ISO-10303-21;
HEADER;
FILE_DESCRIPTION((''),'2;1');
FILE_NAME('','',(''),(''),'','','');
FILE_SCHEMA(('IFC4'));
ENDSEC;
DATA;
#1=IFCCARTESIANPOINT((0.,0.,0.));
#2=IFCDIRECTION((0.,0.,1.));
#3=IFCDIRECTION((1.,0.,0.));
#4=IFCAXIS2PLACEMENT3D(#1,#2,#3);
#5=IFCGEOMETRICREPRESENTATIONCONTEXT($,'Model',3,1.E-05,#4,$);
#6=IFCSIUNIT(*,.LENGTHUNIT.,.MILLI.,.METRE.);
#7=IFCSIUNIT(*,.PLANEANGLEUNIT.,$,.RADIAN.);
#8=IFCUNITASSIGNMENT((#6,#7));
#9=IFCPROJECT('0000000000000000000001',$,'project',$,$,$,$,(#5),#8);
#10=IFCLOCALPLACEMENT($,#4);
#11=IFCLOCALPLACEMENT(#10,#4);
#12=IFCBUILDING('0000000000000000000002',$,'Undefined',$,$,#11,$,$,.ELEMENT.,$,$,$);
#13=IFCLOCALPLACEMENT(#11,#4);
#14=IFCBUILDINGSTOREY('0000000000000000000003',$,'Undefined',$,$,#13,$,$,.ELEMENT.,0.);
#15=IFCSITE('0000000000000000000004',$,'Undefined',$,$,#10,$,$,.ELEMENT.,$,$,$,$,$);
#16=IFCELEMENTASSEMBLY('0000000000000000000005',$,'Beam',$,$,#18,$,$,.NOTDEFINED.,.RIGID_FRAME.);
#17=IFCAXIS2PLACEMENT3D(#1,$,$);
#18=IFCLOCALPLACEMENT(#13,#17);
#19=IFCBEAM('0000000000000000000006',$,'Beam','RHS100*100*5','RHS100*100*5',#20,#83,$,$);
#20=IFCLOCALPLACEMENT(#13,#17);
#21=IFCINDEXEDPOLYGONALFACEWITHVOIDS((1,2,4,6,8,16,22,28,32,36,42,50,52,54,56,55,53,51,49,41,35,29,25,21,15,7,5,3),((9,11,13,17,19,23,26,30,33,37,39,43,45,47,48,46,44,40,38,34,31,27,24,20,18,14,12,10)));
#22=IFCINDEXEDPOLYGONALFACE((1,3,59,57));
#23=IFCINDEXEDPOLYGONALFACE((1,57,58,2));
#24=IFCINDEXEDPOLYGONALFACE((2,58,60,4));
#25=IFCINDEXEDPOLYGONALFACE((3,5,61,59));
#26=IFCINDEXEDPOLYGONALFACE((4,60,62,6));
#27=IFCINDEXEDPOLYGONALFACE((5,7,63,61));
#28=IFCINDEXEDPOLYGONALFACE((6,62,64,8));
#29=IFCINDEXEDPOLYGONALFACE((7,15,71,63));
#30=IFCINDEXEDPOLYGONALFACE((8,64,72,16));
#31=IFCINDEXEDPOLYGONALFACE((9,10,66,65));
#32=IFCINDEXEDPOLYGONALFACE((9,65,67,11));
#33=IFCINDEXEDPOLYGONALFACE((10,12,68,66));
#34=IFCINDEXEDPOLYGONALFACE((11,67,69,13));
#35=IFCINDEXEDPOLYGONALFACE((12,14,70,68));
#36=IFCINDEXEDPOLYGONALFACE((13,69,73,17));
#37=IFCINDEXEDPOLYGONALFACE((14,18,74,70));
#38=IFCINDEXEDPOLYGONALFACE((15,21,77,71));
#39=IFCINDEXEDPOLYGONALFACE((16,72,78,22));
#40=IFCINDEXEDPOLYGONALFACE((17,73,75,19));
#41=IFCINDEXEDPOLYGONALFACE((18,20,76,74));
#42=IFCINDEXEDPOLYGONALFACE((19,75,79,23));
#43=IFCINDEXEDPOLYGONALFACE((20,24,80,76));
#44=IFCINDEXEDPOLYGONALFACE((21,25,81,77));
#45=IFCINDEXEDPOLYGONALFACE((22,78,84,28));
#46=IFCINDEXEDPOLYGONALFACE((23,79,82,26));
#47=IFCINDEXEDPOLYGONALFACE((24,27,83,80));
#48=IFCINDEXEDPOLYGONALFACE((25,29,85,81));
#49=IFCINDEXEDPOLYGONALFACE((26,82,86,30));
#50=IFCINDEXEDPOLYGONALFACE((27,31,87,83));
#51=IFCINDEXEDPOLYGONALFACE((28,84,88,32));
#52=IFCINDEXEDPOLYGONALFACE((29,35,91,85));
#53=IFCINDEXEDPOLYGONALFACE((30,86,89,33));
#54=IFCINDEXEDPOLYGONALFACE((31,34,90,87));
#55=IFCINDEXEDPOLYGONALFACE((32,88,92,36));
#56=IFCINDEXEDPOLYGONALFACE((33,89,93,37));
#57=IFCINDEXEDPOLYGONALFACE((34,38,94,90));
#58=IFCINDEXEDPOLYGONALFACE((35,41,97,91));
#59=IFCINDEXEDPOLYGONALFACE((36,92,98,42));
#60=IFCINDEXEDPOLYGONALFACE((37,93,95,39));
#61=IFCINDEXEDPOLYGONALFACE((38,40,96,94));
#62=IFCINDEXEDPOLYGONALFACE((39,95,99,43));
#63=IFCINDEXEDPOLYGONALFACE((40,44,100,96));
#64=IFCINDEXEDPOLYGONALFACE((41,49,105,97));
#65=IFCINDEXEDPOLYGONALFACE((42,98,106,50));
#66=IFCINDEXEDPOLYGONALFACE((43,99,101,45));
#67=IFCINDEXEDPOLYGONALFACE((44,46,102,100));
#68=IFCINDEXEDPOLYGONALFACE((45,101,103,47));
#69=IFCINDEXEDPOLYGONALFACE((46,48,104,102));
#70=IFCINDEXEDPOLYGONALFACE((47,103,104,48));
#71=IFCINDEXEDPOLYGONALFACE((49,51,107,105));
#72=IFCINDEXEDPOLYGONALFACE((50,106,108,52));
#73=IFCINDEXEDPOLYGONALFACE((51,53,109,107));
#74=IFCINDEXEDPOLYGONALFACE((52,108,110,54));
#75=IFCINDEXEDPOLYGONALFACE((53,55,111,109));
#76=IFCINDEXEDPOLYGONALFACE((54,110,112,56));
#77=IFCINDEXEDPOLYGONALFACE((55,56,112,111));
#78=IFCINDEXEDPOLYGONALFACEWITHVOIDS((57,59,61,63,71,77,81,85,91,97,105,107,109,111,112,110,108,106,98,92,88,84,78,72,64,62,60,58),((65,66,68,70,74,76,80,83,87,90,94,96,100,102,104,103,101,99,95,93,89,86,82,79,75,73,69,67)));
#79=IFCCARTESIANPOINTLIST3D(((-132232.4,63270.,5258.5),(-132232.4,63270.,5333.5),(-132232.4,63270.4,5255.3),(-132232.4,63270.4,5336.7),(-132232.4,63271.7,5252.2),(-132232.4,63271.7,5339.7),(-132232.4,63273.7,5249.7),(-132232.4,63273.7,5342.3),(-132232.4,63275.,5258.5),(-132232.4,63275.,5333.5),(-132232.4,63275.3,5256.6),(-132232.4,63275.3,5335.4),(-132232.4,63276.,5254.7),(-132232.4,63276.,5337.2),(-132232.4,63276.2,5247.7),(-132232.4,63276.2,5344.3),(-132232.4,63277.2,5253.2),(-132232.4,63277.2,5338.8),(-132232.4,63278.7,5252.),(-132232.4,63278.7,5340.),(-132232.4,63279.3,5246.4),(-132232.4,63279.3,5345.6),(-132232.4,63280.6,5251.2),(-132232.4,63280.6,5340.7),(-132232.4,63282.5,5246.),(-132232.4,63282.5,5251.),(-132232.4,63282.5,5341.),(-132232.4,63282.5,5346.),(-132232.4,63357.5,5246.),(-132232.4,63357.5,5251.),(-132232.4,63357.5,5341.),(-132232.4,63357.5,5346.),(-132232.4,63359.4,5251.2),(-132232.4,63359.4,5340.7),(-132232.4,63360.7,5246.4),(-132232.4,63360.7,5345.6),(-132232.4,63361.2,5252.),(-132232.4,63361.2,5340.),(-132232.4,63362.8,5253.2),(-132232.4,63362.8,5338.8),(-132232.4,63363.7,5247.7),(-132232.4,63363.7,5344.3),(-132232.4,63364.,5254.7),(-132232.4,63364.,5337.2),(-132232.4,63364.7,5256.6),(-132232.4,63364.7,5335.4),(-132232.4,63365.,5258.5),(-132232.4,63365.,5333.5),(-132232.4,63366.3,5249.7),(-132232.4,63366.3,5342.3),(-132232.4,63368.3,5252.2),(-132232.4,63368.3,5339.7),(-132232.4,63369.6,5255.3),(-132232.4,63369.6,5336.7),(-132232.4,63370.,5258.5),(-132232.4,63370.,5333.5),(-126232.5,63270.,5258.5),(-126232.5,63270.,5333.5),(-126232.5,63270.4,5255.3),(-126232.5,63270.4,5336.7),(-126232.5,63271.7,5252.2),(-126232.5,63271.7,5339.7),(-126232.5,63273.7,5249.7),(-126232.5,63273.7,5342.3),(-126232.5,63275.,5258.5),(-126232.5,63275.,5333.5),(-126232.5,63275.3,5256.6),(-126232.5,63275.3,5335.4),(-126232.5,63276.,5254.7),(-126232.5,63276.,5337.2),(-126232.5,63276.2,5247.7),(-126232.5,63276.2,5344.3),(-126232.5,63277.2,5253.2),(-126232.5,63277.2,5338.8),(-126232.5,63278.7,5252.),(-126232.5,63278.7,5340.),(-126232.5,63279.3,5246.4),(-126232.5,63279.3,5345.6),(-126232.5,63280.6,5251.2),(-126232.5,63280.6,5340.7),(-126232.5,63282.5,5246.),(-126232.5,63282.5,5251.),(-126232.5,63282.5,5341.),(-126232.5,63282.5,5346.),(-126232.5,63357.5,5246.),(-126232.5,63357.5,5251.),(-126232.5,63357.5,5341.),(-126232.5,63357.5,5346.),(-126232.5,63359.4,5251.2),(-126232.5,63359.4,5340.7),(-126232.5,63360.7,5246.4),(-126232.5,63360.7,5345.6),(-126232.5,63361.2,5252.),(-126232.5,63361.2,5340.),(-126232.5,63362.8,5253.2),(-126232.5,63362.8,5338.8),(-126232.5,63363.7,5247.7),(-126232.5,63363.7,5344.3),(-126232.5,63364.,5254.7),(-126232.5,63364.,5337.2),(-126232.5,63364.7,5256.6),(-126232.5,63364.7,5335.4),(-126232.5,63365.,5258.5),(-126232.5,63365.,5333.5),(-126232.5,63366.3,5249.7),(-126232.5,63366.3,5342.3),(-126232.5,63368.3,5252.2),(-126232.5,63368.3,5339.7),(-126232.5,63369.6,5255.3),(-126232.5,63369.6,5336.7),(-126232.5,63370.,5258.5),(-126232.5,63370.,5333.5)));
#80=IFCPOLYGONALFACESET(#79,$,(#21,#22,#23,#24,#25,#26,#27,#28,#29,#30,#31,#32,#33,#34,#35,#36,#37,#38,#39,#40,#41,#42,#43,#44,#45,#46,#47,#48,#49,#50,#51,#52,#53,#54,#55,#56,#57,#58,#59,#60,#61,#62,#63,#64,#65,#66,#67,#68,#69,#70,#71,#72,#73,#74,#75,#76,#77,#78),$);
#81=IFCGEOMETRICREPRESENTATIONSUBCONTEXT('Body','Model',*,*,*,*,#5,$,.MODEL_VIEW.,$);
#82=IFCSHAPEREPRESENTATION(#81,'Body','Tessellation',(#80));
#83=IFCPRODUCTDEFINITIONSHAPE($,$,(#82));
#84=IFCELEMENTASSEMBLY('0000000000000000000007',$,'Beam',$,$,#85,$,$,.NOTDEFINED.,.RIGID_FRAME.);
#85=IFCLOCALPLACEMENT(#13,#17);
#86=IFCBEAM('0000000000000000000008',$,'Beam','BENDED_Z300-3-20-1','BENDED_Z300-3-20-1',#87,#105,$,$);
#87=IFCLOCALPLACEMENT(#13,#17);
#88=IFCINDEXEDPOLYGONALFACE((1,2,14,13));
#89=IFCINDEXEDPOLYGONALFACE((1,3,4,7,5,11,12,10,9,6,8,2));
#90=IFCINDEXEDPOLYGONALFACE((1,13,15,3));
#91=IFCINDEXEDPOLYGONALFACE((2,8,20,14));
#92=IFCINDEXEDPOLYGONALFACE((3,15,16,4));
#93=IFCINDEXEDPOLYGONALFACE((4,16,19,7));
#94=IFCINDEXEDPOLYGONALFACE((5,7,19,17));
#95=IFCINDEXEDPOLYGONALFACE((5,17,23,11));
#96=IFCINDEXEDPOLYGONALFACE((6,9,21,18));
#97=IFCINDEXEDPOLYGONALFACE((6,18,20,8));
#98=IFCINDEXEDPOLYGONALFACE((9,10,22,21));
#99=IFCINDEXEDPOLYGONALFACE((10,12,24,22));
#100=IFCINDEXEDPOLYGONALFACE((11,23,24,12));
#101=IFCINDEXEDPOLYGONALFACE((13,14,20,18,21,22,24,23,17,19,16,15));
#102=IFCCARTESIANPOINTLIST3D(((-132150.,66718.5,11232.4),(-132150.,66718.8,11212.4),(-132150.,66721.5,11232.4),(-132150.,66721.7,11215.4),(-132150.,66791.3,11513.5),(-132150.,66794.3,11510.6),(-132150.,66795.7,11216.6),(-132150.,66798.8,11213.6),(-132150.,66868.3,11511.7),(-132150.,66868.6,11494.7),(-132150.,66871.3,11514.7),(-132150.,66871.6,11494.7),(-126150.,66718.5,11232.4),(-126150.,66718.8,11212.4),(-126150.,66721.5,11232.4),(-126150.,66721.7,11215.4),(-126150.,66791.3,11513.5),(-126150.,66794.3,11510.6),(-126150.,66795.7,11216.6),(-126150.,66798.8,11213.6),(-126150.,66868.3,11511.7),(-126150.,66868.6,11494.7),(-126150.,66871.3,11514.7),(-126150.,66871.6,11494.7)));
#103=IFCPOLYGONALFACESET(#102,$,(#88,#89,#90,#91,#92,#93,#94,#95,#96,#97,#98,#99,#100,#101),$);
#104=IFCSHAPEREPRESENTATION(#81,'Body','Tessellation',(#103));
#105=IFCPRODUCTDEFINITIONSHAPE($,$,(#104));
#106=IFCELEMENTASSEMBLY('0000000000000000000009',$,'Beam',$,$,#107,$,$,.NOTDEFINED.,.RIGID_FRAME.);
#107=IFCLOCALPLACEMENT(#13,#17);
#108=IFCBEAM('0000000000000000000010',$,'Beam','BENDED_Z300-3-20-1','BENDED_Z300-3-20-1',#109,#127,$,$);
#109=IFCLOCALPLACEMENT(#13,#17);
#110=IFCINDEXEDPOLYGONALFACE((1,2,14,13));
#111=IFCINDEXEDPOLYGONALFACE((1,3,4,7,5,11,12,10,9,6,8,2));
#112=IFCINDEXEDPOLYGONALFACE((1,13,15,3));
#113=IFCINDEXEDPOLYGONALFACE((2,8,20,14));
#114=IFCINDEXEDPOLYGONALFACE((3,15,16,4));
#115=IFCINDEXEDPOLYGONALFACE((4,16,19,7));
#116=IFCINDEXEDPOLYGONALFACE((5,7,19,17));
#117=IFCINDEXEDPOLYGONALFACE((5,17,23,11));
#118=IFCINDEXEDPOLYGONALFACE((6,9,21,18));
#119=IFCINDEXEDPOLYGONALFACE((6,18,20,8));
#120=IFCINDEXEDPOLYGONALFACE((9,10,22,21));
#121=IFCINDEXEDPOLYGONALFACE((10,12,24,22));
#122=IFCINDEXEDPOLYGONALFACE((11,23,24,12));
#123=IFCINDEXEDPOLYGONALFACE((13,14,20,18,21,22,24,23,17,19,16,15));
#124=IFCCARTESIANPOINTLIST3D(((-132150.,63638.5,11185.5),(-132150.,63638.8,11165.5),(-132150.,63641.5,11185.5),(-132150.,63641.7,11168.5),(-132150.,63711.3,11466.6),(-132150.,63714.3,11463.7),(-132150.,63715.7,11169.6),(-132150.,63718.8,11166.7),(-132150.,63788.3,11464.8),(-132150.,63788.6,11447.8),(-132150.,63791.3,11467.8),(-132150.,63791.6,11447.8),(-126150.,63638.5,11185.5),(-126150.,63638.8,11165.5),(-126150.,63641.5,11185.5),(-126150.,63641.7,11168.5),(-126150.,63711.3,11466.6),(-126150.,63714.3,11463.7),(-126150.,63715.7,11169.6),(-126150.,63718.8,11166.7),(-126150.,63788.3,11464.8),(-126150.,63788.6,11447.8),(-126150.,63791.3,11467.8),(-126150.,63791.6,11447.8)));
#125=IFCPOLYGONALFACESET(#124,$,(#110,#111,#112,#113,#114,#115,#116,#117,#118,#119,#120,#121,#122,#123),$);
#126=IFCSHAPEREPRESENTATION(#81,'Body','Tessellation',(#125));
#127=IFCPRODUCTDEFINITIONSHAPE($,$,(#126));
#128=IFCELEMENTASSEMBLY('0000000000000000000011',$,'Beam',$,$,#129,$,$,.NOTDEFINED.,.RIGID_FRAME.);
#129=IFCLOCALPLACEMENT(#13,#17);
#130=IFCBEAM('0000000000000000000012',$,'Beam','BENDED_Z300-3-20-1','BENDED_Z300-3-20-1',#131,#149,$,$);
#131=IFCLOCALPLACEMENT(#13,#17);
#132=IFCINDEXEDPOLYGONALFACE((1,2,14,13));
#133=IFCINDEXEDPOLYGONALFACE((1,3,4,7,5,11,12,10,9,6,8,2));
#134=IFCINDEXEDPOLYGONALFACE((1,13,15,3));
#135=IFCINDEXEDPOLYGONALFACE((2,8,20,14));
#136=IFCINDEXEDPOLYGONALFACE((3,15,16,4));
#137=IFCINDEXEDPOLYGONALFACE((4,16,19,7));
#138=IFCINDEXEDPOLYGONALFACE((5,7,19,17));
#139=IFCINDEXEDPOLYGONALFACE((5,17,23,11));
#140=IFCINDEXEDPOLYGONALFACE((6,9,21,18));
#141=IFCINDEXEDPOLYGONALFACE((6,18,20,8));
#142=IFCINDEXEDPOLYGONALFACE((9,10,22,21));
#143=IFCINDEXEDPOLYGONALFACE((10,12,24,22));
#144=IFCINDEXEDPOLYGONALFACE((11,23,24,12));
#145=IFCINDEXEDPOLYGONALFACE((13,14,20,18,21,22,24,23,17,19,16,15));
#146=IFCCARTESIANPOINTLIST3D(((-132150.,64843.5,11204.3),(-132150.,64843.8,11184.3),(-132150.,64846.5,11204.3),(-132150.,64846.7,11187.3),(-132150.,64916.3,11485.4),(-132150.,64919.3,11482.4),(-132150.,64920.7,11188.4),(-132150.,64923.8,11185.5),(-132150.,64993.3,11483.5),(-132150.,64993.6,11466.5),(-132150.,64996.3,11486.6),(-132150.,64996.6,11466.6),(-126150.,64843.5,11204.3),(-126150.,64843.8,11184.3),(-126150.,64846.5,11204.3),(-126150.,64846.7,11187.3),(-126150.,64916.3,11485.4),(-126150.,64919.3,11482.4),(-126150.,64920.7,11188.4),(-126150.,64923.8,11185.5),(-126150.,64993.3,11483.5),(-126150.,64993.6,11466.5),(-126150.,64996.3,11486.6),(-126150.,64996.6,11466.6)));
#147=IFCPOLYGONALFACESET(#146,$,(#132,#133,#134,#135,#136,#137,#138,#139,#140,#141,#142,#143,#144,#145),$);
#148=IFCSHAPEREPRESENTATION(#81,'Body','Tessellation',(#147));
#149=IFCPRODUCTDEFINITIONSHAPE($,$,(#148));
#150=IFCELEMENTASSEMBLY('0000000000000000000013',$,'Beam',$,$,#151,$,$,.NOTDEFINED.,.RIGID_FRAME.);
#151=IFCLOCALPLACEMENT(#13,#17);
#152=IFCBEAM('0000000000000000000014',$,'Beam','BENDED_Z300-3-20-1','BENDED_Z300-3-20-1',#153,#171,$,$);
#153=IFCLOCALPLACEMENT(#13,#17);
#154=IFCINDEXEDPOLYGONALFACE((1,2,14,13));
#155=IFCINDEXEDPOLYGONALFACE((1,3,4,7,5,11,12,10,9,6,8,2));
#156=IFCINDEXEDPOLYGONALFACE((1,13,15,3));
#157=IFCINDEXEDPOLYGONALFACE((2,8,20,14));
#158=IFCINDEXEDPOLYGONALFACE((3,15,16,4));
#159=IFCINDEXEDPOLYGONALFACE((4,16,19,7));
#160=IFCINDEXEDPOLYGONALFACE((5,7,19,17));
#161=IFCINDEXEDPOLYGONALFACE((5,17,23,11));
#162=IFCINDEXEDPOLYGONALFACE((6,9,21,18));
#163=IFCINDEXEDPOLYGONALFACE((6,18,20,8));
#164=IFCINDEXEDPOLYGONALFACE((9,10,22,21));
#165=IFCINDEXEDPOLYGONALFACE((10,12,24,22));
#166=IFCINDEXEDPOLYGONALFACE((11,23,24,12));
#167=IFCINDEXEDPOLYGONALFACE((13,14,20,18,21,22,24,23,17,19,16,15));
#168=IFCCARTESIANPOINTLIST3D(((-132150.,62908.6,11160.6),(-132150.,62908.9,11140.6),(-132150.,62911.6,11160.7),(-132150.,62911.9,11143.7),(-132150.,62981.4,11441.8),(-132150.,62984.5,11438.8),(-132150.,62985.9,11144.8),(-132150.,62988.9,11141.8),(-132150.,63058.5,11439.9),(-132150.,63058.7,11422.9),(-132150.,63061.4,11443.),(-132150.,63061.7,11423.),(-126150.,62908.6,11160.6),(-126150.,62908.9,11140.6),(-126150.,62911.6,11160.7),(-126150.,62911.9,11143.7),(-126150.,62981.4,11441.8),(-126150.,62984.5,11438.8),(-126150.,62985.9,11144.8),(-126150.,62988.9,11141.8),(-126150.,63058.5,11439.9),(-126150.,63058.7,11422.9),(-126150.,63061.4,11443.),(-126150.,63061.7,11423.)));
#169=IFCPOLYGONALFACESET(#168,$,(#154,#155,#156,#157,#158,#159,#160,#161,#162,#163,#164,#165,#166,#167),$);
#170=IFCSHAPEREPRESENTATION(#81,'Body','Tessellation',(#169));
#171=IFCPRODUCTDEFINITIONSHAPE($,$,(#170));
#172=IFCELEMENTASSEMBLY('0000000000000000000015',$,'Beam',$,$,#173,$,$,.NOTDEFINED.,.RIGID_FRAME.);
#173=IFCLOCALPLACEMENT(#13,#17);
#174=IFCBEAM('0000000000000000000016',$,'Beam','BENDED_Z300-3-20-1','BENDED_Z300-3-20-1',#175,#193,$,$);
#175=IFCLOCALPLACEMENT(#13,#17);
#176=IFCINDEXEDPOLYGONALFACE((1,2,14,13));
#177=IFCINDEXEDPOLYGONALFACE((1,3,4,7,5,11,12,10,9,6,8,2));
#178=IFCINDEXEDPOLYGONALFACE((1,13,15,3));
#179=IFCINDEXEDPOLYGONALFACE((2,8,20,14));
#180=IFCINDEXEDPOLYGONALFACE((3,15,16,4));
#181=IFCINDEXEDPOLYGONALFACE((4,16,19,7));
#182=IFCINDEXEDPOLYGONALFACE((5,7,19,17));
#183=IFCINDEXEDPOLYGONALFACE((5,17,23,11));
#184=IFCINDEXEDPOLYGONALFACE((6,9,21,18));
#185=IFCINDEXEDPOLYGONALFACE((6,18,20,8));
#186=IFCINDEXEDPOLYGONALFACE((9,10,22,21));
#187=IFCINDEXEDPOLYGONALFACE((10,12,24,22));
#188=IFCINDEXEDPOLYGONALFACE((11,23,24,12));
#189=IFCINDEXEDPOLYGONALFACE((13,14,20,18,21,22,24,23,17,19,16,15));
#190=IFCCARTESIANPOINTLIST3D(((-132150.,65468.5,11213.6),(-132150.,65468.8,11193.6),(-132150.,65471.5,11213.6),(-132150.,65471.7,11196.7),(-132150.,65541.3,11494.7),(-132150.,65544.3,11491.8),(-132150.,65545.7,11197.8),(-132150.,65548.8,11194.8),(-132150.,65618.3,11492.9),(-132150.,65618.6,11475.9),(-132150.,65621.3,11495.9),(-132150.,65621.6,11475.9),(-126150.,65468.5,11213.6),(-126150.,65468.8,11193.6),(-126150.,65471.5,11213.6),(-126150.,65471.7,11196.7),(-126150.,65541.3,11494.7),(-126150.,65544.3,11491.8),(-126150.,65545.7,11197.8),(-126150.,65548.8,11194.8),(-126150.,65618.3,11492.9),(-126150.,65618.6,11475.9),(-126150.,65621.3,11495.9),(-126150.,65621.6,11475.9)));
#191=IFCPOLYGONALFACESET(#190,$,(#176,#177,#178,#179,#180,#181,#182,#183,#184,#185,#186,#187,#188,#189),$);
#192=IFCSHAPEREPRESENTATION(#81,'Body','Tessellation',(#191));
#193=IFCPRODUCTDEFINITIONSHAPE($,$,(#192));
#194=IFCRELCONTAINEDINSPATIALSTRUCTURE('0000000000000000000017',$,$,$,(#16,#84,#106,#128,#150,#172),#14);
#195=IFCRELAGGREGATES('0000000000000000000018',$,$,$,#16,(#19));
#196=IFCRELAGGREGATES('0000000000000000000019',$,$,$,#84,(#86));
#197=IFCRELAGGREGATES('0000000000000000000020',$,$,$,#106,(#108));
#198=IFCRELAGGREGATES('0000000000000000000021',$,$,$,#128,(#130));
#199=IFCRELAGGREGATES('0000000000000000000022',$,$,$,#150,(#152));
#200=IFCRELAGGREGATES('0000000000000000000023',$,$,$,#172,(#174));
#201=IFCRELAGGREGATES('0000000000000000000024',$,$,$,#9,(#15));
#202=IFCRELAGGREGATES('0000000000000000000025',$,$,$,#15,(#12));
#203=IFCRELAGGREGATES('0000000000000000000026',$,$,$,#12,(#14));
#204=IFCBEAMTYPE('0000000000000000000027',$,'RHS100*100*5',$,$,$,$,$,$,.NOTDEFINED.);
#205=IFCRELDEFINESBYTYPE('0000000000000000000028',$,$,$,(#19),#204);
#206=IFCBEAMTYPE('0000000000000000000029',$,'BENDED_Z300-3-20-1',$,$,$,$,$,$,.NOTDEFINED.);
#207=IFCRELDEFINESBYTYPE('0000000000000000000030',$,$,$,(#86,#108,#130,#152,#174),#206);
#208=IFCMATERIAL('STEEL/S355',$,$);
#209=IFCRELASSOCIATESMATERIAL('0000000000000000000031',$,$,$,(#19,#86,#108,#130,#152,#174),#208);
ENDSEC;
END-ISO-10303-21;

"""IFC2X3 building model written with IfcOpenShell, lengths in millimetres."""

from ifc_helpers import new_model, si_unit, frame, origin_with_axes, origin_2d_with_axis, place, context, subcontext, project, spatial, polyline, hollow_rectangle, outline, extrude, material, type_object, element, aggregate, save


model = new_model("IFC2X3")

# Units and contexts
model_context = context("Model", 3, precision=1e-05, world=origin_with_axes())
body_context = subcontext(model_context, "Body", "Model", "MODEL_VIEW")
ifc_project = project(units=[si_unit("LENGTHUNIT", "METRE", prefix="MILLI"), si_unit("PLANEANGLEUNIT", "RADIAN")], contexts=[model_context])

# Site, building, storey
site_placement = place(None, origin_with_axes())
site = spatial("IfcSite", under=ifc_project, at=site_placement, Name="Undefined", CompositionType="ELEMENT")
building_placement = place(site_placement, origin_with_axes())
building = spatial("IfcBuilding", under=site, at=building_placement, Name="Undefined", CompositionType="ELEMENT")
storey_placement = place(building_placement, origin_with_axes())
storey = spatial("IfcBuildingStorey", under=building, at=storey_placement, Name="Undefined", CompositionType="ELEMENT", Elevation=0.0)

# Element assemblies, beams
ifc_material_1 = material(Name="STEEL/S355")
beam_type_1 = type_object("IfcBeamType", Name="RHS100*100*5", PredefinedType="NOTDEFINED")
assembly_1_placement = place(storey_placement, origin_with_axes())
assembly_1 = element("IfcElementAssembly", 1, at=assembly_1_placement, inside=storey, Name="Beam", AssemblyPlace="NOTDEFINED", PredefinedType="RIGID_FRAME")
beam_1_placement = place(assembly_1_placement, frame((-126232.5, 63320.0, 5296.0), z_axis=(0.0, 0.0, 1.0), x_axis=(-1.0, 0.0, 0.0)))
beam_1 = element("IfcBeam", 2, at=beam_1_placement, type_object=beam_type_1, material=ifc_material_1, Name="Beam", Description="RHS100*100*5", ObjectType="RHS100*100*5", context=body_context, shape_type="SweptSolid", body=[
    extrude(hollow_rectangle(XDim=100.0, YDim=100.0, WallThickness=5.0, InnerFilletRadius=7.5, OuterFilletRadius=12.5, at=origin_2d_with_axis()), frame((5999.9, 0.0, 0.0), z_axis=(-1.0, 0.0, 0.0), x_axis=(0.0, -1.0, 0.0)), (0.0, 0.0, 1.0), 5999.9),
])
aggregate(assembly_1, [beam_1])
assembly_2_placement = place(storey_placement, origin_with_axes())
assembly_2 = element("IfcElementAssembly", 3, at=assembly_2_placement, inside=storey, Name="Beam", AssemblyPlace="NOTDEFINED", PredefinedType="RIGID_FRAME")
beam_type_2 = type_object("IfcBeamType", Name="BENDED_Z300-3-20-1", PredefinedType="NOTDEFINED")
beam_2_placement = place(assembly_2_placement, frame((-126150.0, 66795.0, 11363.6), z_axis=(0.0, -0.014963, 0.999888), x_axis=(-1.0, 0.0, 0.0)))
beam_2 = element("IfcBeam", 4, at=beam_2_placement, type_object=beam_type_2, material=ifc_material_1, Name="Beam", Description="BENDED_Z300-3-20-1", ObjectType="BENDED_Z300-3-20-1", context=body_context, shape_type="SweptSolid", body=[
    extrude(outline(polyline([(1.5, -150.0), (-78.5, -150.0), (-78.5, -130.0), (-75.5, -130.0), (-75.5, -147.0), (-1.5, -147.0), (-1.5, 150.0), (78.5, 150.0), (78.5, 130.0), (75.5, 130.0), (75.5, 147.0), (1.5, 147.0), (1.5, -150.0)])), frame((6000.0, 0.0, 0.0), z_axis=(-1.0, 0.0, 0.0), x_axis=(0.0, -1.0, 0.0)), (0.0, 0.0, 1.0), 6000.0),
])
aggregate(assembly_2, [beam_2])
assembly_3_placement = place(storey_placement, origin_with_axes())
assembly_3 = element("IfcElementAssembly", 5, at=assembly_3_placement, inside=storey, Name="Beam", AssemblyPlace="NOTDEFINED", PredefinedType="RIGID_FRAME")
beam_3_placement = place(assembly_3_placement, frame((-126150.0, 63715.0, 11316.6), z_axis=(0.0, -0.014963, 0.999888), x_axis=(-1.0, 0.0, 0.0)))
beam_3 = element("IfcBeam", 6, at=beam_3_placement, type_object=beam_type_2, material=ifc_material_1, Name="Beam", Description="BENDED_Z300-3-20-1", ObjectType="BENDED_Z300-3-20-1", context=body_context, shape_type="SweptSolid", body=[
    extrude(outline(polyline([(1.5, -150.0), (-78.5, -150.0), (-78.5, -130.0), (-75.5, -130.0), (-75.5, -147.0), (-1.5, -147.0), (-1.5, 150.0), (78.5, 150.0), (78.5, 130.0), (75.5, 130.0), (75.5, 147.0), (1.5, 147.0), (1.5, -150.0)])), frame((6000.0, 0.0, 0.0), z_axis=(-1.0, 0.0, 0.0), x_axis=(0.0, -1.0, 0.0)), (0.0, 0.0, 1.0), 6000.0),
])
aggregate(assembly_3, [beam_3])
assembly_4_placement = place(storey_placement, origin_with_axes())
assembly_4 = element("IfcElementAssembly", 7, at=assembly_4_placement, inside=storey, Name="Beam", AssemblyPlace="NOTDEFINED", PredefinedType="RIGID_FRAME")
beam_4_placement = place(assembly_4_placement, frame((-126150.0, 64920.0, 11335.4), z_axis=(0.0, -0.014963, 0.999888), x_axis=(-1.0, 0.0, 0.0)))
beam_4 = element("IfcBeam", 8, at=beam_4_placement, type_object=beam_type_2, material=ifc_material_1, Name="Beam", Description="BENDED_Z300-3-20-1", ObjectType="BENDED_Z300-3-20-1", context=body_context, shape_type="SweptSolid", body=[
    extrude(outline(polyline([(1.5, -150.0), (-78.5, -150.0), (-78.5, -130.0), (-75.5, -130.0), (-75.5, -147.0), (-1.5, -147.0), (-1.5, 150.0), (78.5, 150.0), (78.5, 130.0), (75.5, 130.0), (75.5, 147.0), (1.5, 147.0), (1.5, -150.0)])), frame((6000.0, 0.0, 0.0), z_axis=(-1.0, 0.0, 0.0), x_axis=(0.0, -1.0, 0.0)), (0.0, 0.0, 1.0), 6000.0),
])
aggregate(assembly_4, [beam_4])
assembly_5_placement = place(storey_placement, origin_with_axes())
assembly_5 = element("IfcElementAssembly", 9, at=assembly_5_placement, inside=storey, Name="Beam", AssemblyPlace="NOTDEFINED", PredefinedType="RIGID_FRAME")
beam_5_placement = place(assembly_5_placement, frame((-126150.0, 62985.2, 11291.8), z_axis=(0.0, -0.014963, 0.999888), x_axis=(-1.0, 0.0, 0.0)))
beam_5 = element("IfcBeam", 10, at=beam_5_placement, type_object=beam_type_2, material=ifc_material_1, Name="Beam", Description="BENDED_Z300-3-20-1", ObjectType="BENDED_Z300-3-20-1", context=body_context, shape_type="SweptSolid", body=[
    extrude(outline(polyline([(1.5, -150.0), (-78.5, -150.0), (-78.5, -130.0), (-75.5, -130.0), (-75.5, -147.0), (-1.5, -147.0), (-1.5, 150.0), (78.5, 150.0), (78.5, 130.0), (75.5, 130.0), (75.5, 147.0), (1.5, 147.0), (1.5, -150.0)])), frame((6000.0, 0.0, 0.0), z_axis=(-1.0, 0.0, 0.0), x_axis=(0.0, -1.0, 0.0)), (0.0, 0.0, 1.0), 6000.0),
])
aggregate(assembly_5, [beam_5])
assembly_6_placement = place(storey_placement, origin_with_axes())
assembly_6 = element("IfcElementAssembly", 11, at=assembly_6_placement, inside=storey, Name="Beam", AssemblyPlace="NOTDEFINED", PredefinedType="RIGID_FRAME")
beam_6_placement = place(assembly_6_placement, frame((-126150.0, 65545.0, 11344.8), z_axis=(0.0, -0.014963, 0.999888), x_axis=(-1.0, 0.0, 0.0)))
beam_6 = element("IfcBeam", 12, at=beam_6_placement, type_object=beam_type_2, material=ifc_material_1, Name="Beam", Description="BENDED_Z300-3-20-1", ObjectType="BENDED_Z300-3-20-1", context=body_context, shape_type="SweptSolid", body=[
    extrude(outline(polyline([(1.5, -150.0), (-78.5, -150.0), (-78.5, -130.0), (-75.5, -130.0), (-75.5, -147.0), (-1.5, -147.0), (-1.5, 150.0), (78.5, 150.0), (78.5, 130.0), (75.5, 130.0), (75.5, 147.0), (1.5, 147.0), (1.5, -150.0)])), frame((6000.0, 0.0, 0.0), z_axis=(-1.0, 0.0, 0.0), x_axis=(0.0, -1.0, 0.0)), (0.0, 0.0, 1.0), 6000.0),
])
aggregate(assembly_6, [beam_6])

save(model, "model.ifc")
